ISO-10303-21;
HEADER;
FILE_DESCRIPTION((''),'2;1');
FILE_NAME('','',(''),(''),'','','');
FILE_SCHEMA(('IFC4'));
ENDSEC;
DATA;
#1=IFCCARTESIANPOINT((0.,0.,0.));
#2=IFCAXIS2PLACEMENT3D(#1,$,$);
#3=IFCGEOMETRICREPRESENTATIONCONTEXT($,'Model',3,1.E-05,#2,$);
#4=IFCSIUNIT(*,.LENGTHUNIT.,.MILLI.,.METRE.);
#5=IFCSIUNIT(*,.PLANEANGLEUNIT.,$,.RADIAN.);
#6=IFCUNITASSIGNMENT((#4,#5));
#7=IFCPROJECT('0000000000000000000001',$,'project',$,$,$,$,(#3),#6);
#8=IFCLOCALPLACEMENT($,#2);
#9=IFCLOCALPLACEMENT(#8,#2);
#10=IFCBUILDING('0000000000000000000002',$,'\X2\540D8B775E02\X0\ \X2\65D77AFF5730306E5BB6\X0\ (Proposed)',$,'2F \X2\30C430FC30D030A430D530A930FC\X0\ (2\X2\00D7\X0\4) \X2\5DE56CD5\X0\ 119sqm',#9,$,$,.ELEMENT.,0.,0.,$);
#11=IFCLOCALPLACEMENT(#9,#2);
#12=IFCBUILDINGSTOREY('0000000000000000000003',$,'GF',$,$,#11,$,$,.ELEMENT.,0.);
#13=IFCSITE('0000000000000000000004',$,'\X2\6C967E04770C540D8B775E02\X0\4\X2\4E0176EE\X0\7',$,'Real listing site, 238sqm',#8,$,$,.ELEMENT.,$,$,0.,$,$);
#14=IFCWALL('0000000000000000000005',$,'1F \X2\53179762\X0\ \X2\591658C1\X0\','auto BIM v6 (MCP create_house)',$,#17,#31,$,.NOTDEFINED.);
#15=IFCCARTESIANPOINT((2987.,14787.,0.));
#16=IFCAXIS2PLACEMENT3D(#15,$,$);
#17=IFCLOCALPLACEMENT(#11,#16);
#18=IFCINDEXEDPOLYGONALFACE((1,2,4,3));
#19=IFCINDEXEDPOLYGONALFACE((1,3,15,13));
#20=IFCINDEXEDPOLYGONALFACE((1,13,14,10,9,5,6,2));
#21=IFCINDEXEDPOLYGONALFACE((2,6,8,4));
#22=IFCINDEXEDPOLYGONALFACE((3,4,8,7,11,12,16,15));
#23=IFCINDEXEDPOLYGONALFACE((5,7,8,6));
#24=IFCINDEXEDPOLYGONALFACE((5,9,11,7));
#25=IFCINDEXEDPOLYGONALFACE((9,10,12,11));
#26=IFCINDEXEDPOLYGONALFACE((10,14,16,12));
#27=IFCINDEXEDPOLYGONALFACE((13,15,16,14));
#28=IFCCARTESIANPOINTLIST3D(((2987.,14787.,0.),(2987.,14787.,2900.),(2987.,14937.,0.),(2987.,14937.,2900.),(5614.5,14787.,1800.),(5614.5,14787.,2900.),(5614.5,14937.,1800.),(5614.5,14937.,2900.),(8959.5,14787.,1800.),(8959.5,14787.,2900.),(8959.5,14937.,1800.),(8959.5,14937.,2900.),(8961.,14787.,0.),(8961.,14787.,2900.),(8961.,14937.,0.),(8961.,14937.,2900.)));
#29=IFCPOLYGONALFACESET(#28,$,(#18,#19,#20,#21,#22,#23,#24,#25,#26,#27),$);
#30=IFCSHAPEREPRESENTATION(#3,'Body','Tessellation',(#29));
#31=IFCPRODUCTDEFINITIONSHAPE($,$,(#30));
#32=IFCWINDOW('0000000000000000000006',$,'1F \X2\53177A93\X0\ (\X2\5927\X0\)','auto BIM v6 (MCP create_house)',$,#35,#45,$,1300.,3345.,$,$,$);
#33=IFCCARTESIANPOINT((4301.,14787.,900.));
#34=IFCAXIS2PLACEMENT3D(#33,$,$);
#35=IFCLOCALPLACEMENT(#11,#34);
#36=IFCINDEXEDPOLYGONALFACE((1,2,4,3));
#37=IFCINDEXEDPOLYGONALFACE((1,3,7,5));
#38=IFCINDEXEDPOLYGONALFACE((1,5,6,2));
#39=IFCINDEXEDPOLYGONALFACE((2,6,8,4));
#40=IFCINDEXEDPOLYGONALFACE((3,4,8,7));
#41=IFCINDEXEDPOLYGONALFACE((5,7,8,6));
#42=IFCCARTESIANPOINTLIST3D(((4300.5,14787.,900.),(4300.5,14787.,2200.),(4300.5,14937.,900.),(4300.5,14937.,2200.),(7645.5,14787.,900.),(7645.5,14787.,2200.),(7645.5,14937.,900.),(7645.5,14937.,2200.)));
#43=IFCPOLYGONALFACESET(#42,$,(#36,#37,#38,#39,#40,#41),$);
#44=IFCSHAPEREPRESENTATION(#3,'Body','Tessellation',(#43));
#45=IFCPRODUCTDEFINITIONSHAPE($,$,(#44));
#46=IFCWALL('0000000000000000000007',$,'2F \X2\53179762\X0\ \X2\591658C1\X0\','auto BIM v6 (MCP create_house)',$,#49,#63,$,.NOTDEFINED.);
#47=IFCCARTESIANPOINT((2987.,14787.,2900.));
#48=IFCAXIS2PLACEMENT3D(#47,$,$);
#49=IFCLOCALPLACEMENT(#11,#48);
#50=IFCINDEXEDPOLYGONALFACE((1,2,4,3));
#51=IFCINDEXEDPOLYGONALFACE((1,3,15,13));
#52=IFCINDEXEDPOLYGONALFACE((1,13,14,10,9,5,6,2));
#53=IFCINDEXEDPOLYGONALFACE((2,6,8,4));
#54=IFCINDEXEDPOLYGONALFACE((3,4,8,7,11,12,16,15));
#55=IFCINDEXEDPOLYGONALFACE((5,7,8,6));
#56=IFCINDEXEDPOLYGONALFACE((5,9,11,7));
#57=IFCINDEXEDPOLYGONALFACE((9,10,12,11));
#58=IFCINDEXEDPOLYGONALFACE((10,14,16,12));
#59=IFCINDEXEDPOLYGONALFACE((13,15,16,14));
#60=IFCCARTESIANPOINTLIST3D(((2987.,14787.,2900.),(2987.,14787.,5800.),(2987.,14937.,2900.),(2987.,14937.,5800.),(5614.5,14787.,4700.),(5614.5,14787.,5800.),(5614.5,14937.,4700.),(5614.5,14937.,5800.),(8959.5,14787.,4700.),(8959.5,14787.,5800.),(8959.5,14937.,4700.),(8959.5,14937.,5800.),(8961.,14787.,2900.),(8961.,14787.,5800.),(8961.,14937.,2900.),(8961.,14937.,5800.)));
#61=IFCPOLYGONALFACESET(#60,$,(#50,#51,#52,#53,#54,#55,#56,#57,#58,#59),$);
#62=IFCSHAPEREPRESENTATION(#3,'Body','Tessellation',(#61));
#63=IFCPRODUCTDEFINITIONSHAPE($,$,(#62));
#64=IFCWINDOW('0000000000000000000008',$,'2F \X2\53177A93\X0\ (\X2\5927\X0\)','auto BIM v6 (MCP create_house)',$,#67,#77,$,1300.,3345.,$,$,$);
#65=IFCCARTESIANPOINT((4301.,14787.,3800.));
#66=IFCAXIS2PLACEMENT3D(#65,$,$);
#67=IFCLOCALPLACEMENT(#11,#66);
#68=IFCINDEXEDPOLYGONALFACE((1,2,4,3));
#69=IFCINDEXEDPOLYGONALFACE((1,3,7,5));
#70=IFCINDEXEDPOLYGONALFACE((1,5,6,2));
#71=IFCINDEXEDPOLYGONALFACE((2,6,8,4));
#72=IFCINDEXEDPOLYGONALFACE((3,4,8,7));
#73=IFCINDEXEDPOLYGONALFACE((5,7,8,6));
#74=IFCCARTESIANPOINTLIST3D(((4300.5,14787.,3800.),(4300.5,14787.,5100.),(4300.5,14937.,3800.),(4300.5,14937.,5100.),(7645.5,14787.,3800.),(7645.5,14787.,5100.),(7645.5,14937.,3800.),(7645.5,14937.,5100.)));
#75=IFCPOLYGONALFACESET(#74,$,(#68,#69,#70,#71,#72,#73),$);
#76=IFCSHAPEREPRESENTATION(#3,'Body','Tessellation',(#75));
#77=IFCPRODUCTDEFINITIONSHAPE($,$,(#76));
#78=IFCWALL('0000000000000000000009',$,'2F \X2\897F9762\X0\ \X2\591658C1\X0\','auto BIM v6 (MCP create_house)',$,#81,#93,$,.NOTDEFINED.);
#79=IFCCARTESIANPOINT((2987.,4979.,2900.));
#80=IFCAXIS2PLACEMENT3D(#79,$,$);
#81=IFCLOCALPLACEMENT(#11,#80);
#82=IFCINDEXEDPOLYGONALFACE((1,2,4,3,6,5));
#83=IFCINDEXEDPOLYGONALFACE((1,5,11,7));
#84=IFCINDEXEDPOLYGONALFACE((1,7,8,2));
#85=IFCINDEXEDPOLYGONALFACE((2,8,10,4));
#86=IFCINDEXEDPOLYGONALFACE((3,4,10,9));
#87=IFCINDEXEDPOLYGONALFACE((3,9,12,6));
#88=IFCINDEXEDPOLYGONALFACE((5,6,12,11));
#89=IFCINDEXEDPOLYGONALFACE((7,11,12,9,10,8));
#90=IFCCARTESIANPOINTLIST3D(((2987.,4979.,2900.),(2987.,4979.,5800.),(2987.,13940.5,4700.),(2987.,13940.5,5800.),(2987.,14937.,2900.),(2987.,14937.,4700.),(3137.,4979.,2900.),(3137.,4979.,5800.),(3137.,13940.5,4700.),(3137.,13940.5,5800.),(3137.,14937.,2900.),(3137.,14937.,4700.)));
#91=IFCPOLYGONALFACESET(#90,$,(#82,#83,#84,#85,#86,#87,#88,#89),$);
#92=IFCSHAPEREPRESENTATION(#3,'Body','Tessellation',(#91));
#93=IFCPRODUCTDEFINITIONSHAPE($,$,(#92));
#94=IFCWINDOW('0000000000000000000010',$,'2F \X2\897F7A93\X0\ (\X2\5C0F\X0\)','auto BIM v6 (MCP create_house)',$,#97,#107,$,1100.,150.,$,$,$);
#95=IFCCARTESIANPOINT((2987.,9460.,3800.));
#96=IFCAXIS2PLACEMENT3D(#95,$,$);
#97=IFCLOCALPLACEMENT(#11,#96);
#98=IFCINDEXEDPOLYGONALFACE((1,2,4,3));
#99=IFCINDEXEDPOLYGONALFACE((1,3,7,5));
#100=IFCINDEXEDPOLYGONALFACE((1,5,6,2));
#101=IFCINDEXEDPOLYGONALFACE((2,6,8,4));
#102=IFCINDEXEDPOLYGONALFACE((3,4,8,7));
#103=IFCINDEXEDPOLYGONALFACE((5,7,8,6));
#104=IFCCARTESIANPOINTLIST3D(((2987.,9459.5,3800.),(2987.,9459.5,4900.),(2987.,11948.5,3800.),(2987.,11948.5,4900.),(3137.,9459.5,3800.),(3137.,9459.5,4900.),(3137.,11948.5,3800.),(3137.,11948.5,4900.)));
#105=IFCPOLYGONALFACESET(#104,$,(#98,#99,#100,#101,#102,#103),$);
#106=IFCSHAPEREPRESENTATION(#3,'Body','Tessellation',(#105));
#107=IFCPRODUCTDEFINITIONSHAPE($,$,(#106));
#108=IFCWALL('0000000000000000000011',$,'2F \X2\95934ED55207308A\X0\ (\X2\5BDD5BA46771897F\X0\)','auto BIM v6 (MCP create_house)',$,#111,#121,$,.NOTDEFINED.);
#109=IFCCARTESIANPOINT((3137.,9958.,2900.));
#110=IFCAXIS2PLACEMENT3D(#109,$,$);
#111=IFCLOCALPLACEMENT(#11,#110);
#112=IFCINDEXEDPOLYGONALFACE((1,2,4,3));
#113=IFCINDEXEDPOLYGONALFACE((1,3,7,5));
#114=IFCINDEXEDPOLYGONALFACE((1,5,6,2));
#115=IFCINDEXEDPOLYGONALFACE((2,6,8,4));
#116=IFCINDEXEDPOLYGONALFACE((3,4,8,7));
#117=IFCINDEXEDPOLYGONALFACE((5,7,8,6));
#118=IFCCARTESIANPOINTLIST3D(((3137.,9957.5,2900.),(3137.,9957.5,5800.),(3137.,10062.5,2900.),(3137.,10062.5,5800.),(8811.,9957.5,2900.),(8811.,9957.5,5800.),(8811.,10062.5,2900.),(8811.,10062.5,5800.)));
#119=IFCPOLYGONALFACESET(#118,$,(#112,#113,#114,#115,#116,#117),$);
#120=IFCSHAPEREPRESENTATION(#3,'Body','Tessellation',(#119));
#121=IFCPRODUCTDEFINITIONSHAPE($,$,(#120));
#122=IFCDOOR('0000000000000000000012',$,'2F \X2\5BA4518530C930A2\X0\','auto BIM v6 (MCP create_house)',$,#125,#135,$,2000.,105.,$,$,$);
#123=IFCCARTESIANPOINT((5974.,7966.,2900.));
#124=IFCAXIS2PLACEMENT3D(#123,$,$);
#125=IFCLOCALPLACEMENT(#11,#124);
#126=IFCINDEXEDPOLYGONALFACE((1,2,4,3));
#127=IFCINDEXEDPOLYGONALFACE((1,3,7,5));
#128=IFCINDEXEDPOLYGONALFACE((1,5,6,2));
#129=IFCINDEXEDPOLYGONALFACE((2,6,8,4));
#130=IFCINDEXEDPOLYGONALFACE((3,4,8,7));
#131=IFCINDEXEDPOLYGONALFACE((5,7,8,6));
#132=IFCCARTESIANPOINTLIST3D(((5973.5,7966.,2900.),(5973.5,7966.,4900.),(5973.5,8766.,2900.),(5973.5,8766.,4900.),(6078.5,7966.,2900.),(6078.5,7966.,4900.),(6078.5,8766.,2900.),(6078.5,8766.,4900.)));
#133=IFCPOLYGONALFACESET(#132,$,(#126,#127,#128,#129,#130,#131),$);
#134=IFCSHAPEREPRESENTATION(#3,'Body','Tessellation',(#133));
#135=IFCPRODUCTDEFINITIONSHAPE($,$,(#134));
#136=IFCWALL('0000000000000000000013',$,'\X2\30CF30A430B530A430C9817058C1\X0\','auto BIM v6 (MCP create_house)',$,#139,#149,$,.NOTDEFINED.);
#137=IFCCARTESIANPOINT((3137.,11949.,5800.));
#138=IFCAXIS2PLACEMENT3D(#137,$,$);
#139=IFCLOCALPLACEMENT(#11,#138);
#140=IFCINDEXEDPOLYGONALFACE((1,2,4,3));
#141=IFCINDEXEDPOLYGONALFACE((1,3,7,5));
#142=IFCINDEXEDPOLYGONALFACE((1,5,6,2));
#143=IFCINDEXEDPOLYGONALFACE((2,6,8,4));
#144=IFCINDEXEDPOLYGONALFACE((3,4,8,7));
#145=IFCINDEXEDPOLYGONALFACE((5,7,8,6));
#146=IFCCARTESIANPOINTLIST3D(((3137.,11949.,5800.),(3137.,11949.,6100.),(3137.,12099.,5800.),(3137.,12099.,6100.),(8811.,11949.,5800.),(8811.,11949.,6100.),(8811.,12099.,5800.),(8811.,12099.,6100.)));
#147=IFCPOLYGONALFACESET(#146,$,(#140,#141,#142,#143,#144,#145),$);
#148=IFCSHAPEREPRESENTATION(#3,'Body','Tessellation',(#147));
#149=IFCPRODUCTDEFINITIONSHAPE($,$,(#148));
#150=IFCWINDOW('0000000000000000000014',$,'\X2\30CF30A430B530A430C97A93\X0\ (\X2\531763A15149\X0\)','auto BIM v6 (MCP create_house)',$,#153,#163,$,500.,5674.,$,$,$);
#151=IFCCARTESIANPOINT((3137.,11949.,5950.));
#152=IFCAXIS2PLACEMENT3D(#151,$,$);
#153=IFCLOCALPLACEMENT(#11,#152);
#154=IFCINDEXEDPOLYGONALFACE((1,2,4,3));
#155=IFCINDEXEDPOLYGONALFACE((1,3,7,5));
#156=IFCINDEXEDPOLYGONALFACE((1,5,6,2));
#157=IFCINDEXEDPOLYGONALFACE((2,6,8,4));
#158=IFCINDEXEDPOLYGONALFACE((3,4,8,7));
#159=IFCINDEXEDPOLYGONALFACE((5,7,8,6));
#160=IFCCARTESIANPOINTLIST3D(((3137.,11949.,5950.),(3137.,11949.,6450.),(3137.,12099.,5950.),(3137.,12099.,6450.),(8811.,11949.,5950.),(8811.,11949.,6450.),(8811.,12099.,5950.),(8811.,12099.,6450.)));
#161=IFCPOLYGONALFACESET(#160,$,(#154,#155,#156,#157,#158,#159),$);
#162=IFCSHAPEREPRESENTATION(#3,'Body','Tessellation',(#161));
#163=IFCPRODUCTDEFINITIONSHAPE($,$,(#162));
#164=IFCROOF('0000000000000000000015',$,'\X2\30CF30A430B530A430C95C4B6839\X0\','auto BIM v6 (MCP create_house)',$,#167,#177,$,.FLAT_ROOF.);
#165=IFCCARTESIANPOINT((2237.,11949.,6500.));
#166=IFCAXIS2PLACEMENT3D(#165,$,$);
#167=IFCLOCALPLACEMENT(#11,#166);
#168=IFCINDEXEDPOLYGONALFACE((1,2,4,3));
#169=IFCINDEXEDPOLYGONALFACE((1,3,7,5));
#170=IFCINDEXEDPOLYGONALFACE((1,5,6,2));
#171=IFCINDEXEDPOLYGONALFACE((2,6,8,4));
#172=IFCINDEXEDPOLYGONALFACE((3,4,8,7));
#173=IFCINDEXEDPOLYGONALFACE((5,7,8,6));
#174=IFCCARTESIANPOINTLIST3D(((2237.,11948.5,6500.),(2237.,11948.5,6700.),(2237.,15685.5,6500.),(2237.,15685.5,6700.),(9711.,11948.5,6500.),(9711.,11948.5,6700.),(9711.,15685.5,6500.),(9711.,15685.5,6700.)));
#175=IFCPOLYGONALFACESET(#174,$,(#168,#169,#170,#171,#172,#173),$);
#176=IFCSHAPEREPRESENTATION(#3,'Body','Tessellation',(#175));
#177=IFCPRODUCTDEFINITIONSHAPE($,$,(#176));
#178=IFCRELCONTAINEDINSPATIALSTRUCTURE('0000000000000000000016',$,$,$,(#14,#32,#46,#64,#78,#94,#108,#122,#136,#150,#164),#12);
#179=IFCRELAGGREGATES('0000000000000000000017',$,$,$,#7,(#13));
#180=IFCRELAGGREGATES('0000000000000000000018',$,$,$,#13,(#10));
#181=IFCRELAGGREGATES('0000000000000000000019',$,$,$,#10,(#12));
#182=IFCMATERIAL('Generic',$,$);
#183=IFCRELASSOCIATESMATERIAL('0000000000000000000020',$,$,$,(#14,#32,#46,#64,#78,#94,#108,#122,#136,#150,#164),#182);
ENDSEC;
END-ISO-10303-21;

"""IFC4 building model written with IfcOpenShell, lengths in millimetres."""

from ifc_helpers import new_model, si_unit, frame, frame_2d, origin, place, context, project, spatial, rectangle, extrude, material, element, fill, save


model = new_model("IFC4")

# Units and contexts
model_context = context("Model", 3, precision=1e-05, world=origin())
ifc_project = project(units=[si_unit("LENGTHUNIT", "METRE", prefix="MILLI"), si_unit("PLANEANGLEUNIT", "RADIAN")], contexts=[model_context])

# Site, building, storey
site_placement = place(None, origin())
site = spatial("IfcSite", under=ifc_project, at=site_placement, Name="沖縄県名護市4丁目7", ObjectType="Real listing site, 238sqm", CompositionType="ELEMENT", RefElevation=0.0)
building_placement = place(site_placement, origin())
building = spatial("IfcBuilding", under=site, at=building_placement, Name="名護市 旗竿地の家 (Proposed)", ObjectType="2F ツーバイフォー (2×4) 工法 119sqm", CompositionType="ELEMENT", ElevationOfRefHeight=0.0, ElevationOfTerrain=0.0)
storey_placement = place(building_placement, origin())
storey = spatial("IfcBuildingStorey", under=building, at=storey_placement, Name="GF", CompositionType="ELEMENT", Elevation=0.0)

# Wall, opening, window
ifc_material = material(Name="Generic")
wall_1_placement = place(storey_placement, frame((2987.0, 14787.0, 0.0)))
wall_1 = element("IfcWall", 1, at=wall_1_placement, inside=storey, material=ifc_material, Name="1F 北面 外壁", Description="auto BIM v6 (MCP create_house)", PredefinedType="NOTDEFINED", context=model_context, shape_type="SweptSolid", body=[
    extrude(rectangle(XDim=5974.0, YDim=150.0, at=frame_2d((2987.0, 75.0))), frame((2987.0, 14787.0, 0.0)), (0.0, 0.0, 1.0), 2900.0),
])
opening_1_placement = place(storey_placement, frame((4301.0, 14787.0, 900.0)))
opening_1 = element("IfcOpeningElement", 2, at=opening_1_placement, cuts=wall_1, PredefinedType="NOTDEFINED", context=model_context, shape_type="SweptSolid", body=[
    extrude(rectangle(XDim=3345.0, YDim=150.0, at=frame_2d((1672.0, 75.0))), frame((4301.0, 14787.0, 900.0)), (0.0, 0.0, 1.0), 1300.0),
])
window_1_placement = place(storey_placement, frame((4301.0, 14787.0, 900.0)))
window_1 = element("IfcWindow", 3, at=window_1_placement, inside=storey, material=ifc_material, Name="1F 北窓 (大)", Description="auto BIM v6 (MCP create_house)", OverallHeight=1300.0, OverallWidth=3345.0, context=model_context, shape_type="SweptSolid", body=[
    extrude(rectangle(XDim=3345.0, YDim=150.0, at=frame_2d((1672.0, 75.0))), frame((4301.0, 14787.0, 900.0)), (0.0, 0.0, 1.0), 1300.0),
])
fill(opening_1, window_1)

# Walls, openings, windows
wall_2_placement = place(storey_placement, frame((2987.0, 14787.0, 2900.0)))
wall_2 = element("IfcWall", 4, at=wall_2_placement, inside=storey, material=ifc_material, Name="2F 北面 外壁", Description="auto BIM v6 (MCP create_house)", PredefinedType="NOTDEFINED", context=model_context, shape_type="SweptSolid", body=[
    extrude(rectangle(XDim=5974.0, YDim=150.0, at=frame_2d((2987.0, 75.0))), frame((2987.0, 14787.0, 2900.0)), (0.0, 0.0, 1.0), 2900.0),
])
opening_2_placement = place(storey_placement, frame((4301.0, 14787.0, 3800.0)))
opening_2 = element("IfcOpeningElement", 5, at=opening_2_placement, cuts=wall_2, PredefinedType="NOTDEFINED", context=model_context, shape_type="SweptSolid", body=[
    extrude(rectangle(XDim=3345.0, YDim=150.0, at=frame_2d((1672.0, 75.0))), frame((4301.0, 14787.0, 3800.0)), (0.0, 0.0, 1.0), 1300.0),
])
window_2_placement = place(storey_placement, frame((4301.0, 14787.0, 3800.0)))
window_2 = element("IfcWindow", 6, at=window_2_placement, inside=storey, material=ifc_material, Name="2F 北窓 (大)", Description="auto BIM v6 (MCP create_house)", OverallHeight=1300.0, OverallWidth=3345.0, context=model_context, shape_type="SweptSolid", body=[
    extrude(rectangle(XDim=3345.0, YDim=150.0, at=frame_2d((1672.0, 75.0))), frame((4301.0, 14787.0, 3800.0)), (0.0, 0.0, 1.0), 1300.0),
])
fill(opening_2, window_2)
wall_3_placement = place(storey_placement, frame((2987.0, 4979.0, 2900.0)))
wall_3 = element("IfcWall", 7, at=wall_3_placement, inside=storey, material=ifc_material, Name="2F 西面 外壁", Description="auto BIM v6 (MCP create_house)", PredefinedType="NOTDEFINED", context=model_context, shape_type="SweptSolid", body=[
    extrude(rectangle(XDim=150.0, YDim=9958.0, at=frame_2d((75.0, 4979.0))), frame((2987.0, 4979.0, 2900.0)), (0.0, 0.0, 1.0), 2900.0),
])
opening_3_placement = place(storey_placement, frame((2987.0, 9460.0, 3800.0)))
opening_3 = element("IfcOpeningElement", 8, at=opening_3_placement, cuts=wall_3, PredefinedType="NOTDEFINED", context=model_context, shape_type="SweptSolid", body=[
    extrude(rectangle(XDim=150.0, YDim=2489.0, at=frame_2d((75.0, 1244.0))), frame((2987.0, 9460.0, 3800.0)), (0.0, 0.0, 1.0), 1100.0),
])
window_3_placement = place(storey_placement, frame((2987.0, 9460.0, 3800.0)))
window_3 = element("IfcWindow", 9, at=window_3_placement, inside=storey, material=ifc_material, Name="2F 西窓 (小)", Description="auto BIM v6 (MCP create_house)", OverallHeight=1100.0, OverallWidth=150.0, context=model_context, shape_type="SweptSolid", body=[
    extrude(rectangle(XDim=150.0, YDim=2489.0, at=frame_2d((75.0, 1244.0))), frame((2987.0, 9460.0, 3800.0)), (0.0, 0.0, 1.0), 1100.0),
])
fill(opening_3, window_3)

# Wall
wall_4_placement = place(storey_placement, frame((3137.0, 9958.0, 2900.0)))
element("IfcWall", 10, at=wall_4_placement, inside=storey, material=ifc_material, Name="2F 間仕切り (寝室東西)", Description="auto BIM v6 (MCP create_house)", PredefinedType="NOTDEFINED", context=model_context, shape_type="SweptSolid", body=[
    extrude(rectangle(XDim=5674.0, YDim=105.0, at=frame_2d((2837.0, 52.0))), frame((3137.0, 9958.0, 2900.0)), (0.0, 0.0, 1.0), 2900.0),
])

# Door
door_placement = place(storey_placement, frame((5974.0, 7966.0, 2900.0)))
element("IfcDoor", 11, at=door_placement, inside=storey, material=ifc_material, Name="2F 室内ドア", Description="auto BIM v6 (MCP create_house)", OverallHeight=2000.0, OverallWidth=105.0, context=model_context, shape_type="SweptSolid", body=[
    extrude(rectangle(XDim=105.0, YDim=800.0, at=frame_2d((52.0, 400.0))), frame((5974.0, 7966.0, 2900.0)), (0.0, 0.0, 1.0), 2000.0),
])

# Wall, opening, window
wall_5_placement = place(storey_placement, frame((3137.0, 11949.0, 5800.0)))
wall_5 = element("IfcWall", 12, at=wall_5_placement, inside=storey, material=ifc_material, Name="ハイサイド腰壁", Description="auto BIM v6 (MCP create_house)", PredefinedType="NOTDEFINED", context=model_context, shape_type="SweptSolid", body=[
    extrude(rectangle(XDim=5674.0, YDim=150.0, at=frame_2d((2837.0, 75.0))), frame((3137.0, 11949.0, 5800.0)), (0.0, 0.0, 1.0), 700.0),
])
opening_4_placement = place(storey_placement, frame((3137.0, 11949.0, 5950.0)))
opening_4 = element("IfcOpeningElement", 13, at=opening_4_placement, cuts=wall_5, PredefinedType="NOTDEFINED", context=model_context, shape_type="SweptSolid", body=[
    extrude(rectangle(XDim=5674.0, YDim=150.0, at=frame_2d((2837.0, 75.0))), frame((3137.0, 11949.0, 5950.0)), (0.0, 0.0, 1.0), 500.0),
])
window_4_placement = place(storey_placement, frame((3137.0, 11949.0, 5950.0)))
window_4 = element("IfcWindow", 14, at=window_4_placement, inside=storey, material=ifc_material, Name="ハイサイド窓 (北採光)", Description="auto BIM v6 (MCP create_house)", OverallHeight=500.0, OverallWidth=5674.0, context=model_context, shape_type="SweptSolid", body=[
    extrude(rectangle(XDim=5674.0, YDim=150.0, at=frame_2d((2837.0, 75.0))), frame((3137.0, 11949.0, 5950.0)), (0.0, 0.0, 1.0), 500.0),
])
fill(opening_4, window_4)

# Roof
roof_placement = place(storey_placement, frame((2237.0, 11949.0, 6500.0)))
element("IfcRoof", 15, at=roof_placement, inside=storey, material=ifc_material, Name="ハイサイド屋根", Description="auto BIM v6 (MCP create_house)", PredefinedType="FLAT_ROOF", context=model_context, shape_type="SweptSolid", body=[
    extrude(rectangle(XDim=7474.0, YDim=3737.0, at=frame_2d((3737.0, 1868.0))), frame((2237.0, 11949.0, 6500.0)), (0.0, 0.0, 1.0), 200.0),
])

save(model, "model.ifc")
